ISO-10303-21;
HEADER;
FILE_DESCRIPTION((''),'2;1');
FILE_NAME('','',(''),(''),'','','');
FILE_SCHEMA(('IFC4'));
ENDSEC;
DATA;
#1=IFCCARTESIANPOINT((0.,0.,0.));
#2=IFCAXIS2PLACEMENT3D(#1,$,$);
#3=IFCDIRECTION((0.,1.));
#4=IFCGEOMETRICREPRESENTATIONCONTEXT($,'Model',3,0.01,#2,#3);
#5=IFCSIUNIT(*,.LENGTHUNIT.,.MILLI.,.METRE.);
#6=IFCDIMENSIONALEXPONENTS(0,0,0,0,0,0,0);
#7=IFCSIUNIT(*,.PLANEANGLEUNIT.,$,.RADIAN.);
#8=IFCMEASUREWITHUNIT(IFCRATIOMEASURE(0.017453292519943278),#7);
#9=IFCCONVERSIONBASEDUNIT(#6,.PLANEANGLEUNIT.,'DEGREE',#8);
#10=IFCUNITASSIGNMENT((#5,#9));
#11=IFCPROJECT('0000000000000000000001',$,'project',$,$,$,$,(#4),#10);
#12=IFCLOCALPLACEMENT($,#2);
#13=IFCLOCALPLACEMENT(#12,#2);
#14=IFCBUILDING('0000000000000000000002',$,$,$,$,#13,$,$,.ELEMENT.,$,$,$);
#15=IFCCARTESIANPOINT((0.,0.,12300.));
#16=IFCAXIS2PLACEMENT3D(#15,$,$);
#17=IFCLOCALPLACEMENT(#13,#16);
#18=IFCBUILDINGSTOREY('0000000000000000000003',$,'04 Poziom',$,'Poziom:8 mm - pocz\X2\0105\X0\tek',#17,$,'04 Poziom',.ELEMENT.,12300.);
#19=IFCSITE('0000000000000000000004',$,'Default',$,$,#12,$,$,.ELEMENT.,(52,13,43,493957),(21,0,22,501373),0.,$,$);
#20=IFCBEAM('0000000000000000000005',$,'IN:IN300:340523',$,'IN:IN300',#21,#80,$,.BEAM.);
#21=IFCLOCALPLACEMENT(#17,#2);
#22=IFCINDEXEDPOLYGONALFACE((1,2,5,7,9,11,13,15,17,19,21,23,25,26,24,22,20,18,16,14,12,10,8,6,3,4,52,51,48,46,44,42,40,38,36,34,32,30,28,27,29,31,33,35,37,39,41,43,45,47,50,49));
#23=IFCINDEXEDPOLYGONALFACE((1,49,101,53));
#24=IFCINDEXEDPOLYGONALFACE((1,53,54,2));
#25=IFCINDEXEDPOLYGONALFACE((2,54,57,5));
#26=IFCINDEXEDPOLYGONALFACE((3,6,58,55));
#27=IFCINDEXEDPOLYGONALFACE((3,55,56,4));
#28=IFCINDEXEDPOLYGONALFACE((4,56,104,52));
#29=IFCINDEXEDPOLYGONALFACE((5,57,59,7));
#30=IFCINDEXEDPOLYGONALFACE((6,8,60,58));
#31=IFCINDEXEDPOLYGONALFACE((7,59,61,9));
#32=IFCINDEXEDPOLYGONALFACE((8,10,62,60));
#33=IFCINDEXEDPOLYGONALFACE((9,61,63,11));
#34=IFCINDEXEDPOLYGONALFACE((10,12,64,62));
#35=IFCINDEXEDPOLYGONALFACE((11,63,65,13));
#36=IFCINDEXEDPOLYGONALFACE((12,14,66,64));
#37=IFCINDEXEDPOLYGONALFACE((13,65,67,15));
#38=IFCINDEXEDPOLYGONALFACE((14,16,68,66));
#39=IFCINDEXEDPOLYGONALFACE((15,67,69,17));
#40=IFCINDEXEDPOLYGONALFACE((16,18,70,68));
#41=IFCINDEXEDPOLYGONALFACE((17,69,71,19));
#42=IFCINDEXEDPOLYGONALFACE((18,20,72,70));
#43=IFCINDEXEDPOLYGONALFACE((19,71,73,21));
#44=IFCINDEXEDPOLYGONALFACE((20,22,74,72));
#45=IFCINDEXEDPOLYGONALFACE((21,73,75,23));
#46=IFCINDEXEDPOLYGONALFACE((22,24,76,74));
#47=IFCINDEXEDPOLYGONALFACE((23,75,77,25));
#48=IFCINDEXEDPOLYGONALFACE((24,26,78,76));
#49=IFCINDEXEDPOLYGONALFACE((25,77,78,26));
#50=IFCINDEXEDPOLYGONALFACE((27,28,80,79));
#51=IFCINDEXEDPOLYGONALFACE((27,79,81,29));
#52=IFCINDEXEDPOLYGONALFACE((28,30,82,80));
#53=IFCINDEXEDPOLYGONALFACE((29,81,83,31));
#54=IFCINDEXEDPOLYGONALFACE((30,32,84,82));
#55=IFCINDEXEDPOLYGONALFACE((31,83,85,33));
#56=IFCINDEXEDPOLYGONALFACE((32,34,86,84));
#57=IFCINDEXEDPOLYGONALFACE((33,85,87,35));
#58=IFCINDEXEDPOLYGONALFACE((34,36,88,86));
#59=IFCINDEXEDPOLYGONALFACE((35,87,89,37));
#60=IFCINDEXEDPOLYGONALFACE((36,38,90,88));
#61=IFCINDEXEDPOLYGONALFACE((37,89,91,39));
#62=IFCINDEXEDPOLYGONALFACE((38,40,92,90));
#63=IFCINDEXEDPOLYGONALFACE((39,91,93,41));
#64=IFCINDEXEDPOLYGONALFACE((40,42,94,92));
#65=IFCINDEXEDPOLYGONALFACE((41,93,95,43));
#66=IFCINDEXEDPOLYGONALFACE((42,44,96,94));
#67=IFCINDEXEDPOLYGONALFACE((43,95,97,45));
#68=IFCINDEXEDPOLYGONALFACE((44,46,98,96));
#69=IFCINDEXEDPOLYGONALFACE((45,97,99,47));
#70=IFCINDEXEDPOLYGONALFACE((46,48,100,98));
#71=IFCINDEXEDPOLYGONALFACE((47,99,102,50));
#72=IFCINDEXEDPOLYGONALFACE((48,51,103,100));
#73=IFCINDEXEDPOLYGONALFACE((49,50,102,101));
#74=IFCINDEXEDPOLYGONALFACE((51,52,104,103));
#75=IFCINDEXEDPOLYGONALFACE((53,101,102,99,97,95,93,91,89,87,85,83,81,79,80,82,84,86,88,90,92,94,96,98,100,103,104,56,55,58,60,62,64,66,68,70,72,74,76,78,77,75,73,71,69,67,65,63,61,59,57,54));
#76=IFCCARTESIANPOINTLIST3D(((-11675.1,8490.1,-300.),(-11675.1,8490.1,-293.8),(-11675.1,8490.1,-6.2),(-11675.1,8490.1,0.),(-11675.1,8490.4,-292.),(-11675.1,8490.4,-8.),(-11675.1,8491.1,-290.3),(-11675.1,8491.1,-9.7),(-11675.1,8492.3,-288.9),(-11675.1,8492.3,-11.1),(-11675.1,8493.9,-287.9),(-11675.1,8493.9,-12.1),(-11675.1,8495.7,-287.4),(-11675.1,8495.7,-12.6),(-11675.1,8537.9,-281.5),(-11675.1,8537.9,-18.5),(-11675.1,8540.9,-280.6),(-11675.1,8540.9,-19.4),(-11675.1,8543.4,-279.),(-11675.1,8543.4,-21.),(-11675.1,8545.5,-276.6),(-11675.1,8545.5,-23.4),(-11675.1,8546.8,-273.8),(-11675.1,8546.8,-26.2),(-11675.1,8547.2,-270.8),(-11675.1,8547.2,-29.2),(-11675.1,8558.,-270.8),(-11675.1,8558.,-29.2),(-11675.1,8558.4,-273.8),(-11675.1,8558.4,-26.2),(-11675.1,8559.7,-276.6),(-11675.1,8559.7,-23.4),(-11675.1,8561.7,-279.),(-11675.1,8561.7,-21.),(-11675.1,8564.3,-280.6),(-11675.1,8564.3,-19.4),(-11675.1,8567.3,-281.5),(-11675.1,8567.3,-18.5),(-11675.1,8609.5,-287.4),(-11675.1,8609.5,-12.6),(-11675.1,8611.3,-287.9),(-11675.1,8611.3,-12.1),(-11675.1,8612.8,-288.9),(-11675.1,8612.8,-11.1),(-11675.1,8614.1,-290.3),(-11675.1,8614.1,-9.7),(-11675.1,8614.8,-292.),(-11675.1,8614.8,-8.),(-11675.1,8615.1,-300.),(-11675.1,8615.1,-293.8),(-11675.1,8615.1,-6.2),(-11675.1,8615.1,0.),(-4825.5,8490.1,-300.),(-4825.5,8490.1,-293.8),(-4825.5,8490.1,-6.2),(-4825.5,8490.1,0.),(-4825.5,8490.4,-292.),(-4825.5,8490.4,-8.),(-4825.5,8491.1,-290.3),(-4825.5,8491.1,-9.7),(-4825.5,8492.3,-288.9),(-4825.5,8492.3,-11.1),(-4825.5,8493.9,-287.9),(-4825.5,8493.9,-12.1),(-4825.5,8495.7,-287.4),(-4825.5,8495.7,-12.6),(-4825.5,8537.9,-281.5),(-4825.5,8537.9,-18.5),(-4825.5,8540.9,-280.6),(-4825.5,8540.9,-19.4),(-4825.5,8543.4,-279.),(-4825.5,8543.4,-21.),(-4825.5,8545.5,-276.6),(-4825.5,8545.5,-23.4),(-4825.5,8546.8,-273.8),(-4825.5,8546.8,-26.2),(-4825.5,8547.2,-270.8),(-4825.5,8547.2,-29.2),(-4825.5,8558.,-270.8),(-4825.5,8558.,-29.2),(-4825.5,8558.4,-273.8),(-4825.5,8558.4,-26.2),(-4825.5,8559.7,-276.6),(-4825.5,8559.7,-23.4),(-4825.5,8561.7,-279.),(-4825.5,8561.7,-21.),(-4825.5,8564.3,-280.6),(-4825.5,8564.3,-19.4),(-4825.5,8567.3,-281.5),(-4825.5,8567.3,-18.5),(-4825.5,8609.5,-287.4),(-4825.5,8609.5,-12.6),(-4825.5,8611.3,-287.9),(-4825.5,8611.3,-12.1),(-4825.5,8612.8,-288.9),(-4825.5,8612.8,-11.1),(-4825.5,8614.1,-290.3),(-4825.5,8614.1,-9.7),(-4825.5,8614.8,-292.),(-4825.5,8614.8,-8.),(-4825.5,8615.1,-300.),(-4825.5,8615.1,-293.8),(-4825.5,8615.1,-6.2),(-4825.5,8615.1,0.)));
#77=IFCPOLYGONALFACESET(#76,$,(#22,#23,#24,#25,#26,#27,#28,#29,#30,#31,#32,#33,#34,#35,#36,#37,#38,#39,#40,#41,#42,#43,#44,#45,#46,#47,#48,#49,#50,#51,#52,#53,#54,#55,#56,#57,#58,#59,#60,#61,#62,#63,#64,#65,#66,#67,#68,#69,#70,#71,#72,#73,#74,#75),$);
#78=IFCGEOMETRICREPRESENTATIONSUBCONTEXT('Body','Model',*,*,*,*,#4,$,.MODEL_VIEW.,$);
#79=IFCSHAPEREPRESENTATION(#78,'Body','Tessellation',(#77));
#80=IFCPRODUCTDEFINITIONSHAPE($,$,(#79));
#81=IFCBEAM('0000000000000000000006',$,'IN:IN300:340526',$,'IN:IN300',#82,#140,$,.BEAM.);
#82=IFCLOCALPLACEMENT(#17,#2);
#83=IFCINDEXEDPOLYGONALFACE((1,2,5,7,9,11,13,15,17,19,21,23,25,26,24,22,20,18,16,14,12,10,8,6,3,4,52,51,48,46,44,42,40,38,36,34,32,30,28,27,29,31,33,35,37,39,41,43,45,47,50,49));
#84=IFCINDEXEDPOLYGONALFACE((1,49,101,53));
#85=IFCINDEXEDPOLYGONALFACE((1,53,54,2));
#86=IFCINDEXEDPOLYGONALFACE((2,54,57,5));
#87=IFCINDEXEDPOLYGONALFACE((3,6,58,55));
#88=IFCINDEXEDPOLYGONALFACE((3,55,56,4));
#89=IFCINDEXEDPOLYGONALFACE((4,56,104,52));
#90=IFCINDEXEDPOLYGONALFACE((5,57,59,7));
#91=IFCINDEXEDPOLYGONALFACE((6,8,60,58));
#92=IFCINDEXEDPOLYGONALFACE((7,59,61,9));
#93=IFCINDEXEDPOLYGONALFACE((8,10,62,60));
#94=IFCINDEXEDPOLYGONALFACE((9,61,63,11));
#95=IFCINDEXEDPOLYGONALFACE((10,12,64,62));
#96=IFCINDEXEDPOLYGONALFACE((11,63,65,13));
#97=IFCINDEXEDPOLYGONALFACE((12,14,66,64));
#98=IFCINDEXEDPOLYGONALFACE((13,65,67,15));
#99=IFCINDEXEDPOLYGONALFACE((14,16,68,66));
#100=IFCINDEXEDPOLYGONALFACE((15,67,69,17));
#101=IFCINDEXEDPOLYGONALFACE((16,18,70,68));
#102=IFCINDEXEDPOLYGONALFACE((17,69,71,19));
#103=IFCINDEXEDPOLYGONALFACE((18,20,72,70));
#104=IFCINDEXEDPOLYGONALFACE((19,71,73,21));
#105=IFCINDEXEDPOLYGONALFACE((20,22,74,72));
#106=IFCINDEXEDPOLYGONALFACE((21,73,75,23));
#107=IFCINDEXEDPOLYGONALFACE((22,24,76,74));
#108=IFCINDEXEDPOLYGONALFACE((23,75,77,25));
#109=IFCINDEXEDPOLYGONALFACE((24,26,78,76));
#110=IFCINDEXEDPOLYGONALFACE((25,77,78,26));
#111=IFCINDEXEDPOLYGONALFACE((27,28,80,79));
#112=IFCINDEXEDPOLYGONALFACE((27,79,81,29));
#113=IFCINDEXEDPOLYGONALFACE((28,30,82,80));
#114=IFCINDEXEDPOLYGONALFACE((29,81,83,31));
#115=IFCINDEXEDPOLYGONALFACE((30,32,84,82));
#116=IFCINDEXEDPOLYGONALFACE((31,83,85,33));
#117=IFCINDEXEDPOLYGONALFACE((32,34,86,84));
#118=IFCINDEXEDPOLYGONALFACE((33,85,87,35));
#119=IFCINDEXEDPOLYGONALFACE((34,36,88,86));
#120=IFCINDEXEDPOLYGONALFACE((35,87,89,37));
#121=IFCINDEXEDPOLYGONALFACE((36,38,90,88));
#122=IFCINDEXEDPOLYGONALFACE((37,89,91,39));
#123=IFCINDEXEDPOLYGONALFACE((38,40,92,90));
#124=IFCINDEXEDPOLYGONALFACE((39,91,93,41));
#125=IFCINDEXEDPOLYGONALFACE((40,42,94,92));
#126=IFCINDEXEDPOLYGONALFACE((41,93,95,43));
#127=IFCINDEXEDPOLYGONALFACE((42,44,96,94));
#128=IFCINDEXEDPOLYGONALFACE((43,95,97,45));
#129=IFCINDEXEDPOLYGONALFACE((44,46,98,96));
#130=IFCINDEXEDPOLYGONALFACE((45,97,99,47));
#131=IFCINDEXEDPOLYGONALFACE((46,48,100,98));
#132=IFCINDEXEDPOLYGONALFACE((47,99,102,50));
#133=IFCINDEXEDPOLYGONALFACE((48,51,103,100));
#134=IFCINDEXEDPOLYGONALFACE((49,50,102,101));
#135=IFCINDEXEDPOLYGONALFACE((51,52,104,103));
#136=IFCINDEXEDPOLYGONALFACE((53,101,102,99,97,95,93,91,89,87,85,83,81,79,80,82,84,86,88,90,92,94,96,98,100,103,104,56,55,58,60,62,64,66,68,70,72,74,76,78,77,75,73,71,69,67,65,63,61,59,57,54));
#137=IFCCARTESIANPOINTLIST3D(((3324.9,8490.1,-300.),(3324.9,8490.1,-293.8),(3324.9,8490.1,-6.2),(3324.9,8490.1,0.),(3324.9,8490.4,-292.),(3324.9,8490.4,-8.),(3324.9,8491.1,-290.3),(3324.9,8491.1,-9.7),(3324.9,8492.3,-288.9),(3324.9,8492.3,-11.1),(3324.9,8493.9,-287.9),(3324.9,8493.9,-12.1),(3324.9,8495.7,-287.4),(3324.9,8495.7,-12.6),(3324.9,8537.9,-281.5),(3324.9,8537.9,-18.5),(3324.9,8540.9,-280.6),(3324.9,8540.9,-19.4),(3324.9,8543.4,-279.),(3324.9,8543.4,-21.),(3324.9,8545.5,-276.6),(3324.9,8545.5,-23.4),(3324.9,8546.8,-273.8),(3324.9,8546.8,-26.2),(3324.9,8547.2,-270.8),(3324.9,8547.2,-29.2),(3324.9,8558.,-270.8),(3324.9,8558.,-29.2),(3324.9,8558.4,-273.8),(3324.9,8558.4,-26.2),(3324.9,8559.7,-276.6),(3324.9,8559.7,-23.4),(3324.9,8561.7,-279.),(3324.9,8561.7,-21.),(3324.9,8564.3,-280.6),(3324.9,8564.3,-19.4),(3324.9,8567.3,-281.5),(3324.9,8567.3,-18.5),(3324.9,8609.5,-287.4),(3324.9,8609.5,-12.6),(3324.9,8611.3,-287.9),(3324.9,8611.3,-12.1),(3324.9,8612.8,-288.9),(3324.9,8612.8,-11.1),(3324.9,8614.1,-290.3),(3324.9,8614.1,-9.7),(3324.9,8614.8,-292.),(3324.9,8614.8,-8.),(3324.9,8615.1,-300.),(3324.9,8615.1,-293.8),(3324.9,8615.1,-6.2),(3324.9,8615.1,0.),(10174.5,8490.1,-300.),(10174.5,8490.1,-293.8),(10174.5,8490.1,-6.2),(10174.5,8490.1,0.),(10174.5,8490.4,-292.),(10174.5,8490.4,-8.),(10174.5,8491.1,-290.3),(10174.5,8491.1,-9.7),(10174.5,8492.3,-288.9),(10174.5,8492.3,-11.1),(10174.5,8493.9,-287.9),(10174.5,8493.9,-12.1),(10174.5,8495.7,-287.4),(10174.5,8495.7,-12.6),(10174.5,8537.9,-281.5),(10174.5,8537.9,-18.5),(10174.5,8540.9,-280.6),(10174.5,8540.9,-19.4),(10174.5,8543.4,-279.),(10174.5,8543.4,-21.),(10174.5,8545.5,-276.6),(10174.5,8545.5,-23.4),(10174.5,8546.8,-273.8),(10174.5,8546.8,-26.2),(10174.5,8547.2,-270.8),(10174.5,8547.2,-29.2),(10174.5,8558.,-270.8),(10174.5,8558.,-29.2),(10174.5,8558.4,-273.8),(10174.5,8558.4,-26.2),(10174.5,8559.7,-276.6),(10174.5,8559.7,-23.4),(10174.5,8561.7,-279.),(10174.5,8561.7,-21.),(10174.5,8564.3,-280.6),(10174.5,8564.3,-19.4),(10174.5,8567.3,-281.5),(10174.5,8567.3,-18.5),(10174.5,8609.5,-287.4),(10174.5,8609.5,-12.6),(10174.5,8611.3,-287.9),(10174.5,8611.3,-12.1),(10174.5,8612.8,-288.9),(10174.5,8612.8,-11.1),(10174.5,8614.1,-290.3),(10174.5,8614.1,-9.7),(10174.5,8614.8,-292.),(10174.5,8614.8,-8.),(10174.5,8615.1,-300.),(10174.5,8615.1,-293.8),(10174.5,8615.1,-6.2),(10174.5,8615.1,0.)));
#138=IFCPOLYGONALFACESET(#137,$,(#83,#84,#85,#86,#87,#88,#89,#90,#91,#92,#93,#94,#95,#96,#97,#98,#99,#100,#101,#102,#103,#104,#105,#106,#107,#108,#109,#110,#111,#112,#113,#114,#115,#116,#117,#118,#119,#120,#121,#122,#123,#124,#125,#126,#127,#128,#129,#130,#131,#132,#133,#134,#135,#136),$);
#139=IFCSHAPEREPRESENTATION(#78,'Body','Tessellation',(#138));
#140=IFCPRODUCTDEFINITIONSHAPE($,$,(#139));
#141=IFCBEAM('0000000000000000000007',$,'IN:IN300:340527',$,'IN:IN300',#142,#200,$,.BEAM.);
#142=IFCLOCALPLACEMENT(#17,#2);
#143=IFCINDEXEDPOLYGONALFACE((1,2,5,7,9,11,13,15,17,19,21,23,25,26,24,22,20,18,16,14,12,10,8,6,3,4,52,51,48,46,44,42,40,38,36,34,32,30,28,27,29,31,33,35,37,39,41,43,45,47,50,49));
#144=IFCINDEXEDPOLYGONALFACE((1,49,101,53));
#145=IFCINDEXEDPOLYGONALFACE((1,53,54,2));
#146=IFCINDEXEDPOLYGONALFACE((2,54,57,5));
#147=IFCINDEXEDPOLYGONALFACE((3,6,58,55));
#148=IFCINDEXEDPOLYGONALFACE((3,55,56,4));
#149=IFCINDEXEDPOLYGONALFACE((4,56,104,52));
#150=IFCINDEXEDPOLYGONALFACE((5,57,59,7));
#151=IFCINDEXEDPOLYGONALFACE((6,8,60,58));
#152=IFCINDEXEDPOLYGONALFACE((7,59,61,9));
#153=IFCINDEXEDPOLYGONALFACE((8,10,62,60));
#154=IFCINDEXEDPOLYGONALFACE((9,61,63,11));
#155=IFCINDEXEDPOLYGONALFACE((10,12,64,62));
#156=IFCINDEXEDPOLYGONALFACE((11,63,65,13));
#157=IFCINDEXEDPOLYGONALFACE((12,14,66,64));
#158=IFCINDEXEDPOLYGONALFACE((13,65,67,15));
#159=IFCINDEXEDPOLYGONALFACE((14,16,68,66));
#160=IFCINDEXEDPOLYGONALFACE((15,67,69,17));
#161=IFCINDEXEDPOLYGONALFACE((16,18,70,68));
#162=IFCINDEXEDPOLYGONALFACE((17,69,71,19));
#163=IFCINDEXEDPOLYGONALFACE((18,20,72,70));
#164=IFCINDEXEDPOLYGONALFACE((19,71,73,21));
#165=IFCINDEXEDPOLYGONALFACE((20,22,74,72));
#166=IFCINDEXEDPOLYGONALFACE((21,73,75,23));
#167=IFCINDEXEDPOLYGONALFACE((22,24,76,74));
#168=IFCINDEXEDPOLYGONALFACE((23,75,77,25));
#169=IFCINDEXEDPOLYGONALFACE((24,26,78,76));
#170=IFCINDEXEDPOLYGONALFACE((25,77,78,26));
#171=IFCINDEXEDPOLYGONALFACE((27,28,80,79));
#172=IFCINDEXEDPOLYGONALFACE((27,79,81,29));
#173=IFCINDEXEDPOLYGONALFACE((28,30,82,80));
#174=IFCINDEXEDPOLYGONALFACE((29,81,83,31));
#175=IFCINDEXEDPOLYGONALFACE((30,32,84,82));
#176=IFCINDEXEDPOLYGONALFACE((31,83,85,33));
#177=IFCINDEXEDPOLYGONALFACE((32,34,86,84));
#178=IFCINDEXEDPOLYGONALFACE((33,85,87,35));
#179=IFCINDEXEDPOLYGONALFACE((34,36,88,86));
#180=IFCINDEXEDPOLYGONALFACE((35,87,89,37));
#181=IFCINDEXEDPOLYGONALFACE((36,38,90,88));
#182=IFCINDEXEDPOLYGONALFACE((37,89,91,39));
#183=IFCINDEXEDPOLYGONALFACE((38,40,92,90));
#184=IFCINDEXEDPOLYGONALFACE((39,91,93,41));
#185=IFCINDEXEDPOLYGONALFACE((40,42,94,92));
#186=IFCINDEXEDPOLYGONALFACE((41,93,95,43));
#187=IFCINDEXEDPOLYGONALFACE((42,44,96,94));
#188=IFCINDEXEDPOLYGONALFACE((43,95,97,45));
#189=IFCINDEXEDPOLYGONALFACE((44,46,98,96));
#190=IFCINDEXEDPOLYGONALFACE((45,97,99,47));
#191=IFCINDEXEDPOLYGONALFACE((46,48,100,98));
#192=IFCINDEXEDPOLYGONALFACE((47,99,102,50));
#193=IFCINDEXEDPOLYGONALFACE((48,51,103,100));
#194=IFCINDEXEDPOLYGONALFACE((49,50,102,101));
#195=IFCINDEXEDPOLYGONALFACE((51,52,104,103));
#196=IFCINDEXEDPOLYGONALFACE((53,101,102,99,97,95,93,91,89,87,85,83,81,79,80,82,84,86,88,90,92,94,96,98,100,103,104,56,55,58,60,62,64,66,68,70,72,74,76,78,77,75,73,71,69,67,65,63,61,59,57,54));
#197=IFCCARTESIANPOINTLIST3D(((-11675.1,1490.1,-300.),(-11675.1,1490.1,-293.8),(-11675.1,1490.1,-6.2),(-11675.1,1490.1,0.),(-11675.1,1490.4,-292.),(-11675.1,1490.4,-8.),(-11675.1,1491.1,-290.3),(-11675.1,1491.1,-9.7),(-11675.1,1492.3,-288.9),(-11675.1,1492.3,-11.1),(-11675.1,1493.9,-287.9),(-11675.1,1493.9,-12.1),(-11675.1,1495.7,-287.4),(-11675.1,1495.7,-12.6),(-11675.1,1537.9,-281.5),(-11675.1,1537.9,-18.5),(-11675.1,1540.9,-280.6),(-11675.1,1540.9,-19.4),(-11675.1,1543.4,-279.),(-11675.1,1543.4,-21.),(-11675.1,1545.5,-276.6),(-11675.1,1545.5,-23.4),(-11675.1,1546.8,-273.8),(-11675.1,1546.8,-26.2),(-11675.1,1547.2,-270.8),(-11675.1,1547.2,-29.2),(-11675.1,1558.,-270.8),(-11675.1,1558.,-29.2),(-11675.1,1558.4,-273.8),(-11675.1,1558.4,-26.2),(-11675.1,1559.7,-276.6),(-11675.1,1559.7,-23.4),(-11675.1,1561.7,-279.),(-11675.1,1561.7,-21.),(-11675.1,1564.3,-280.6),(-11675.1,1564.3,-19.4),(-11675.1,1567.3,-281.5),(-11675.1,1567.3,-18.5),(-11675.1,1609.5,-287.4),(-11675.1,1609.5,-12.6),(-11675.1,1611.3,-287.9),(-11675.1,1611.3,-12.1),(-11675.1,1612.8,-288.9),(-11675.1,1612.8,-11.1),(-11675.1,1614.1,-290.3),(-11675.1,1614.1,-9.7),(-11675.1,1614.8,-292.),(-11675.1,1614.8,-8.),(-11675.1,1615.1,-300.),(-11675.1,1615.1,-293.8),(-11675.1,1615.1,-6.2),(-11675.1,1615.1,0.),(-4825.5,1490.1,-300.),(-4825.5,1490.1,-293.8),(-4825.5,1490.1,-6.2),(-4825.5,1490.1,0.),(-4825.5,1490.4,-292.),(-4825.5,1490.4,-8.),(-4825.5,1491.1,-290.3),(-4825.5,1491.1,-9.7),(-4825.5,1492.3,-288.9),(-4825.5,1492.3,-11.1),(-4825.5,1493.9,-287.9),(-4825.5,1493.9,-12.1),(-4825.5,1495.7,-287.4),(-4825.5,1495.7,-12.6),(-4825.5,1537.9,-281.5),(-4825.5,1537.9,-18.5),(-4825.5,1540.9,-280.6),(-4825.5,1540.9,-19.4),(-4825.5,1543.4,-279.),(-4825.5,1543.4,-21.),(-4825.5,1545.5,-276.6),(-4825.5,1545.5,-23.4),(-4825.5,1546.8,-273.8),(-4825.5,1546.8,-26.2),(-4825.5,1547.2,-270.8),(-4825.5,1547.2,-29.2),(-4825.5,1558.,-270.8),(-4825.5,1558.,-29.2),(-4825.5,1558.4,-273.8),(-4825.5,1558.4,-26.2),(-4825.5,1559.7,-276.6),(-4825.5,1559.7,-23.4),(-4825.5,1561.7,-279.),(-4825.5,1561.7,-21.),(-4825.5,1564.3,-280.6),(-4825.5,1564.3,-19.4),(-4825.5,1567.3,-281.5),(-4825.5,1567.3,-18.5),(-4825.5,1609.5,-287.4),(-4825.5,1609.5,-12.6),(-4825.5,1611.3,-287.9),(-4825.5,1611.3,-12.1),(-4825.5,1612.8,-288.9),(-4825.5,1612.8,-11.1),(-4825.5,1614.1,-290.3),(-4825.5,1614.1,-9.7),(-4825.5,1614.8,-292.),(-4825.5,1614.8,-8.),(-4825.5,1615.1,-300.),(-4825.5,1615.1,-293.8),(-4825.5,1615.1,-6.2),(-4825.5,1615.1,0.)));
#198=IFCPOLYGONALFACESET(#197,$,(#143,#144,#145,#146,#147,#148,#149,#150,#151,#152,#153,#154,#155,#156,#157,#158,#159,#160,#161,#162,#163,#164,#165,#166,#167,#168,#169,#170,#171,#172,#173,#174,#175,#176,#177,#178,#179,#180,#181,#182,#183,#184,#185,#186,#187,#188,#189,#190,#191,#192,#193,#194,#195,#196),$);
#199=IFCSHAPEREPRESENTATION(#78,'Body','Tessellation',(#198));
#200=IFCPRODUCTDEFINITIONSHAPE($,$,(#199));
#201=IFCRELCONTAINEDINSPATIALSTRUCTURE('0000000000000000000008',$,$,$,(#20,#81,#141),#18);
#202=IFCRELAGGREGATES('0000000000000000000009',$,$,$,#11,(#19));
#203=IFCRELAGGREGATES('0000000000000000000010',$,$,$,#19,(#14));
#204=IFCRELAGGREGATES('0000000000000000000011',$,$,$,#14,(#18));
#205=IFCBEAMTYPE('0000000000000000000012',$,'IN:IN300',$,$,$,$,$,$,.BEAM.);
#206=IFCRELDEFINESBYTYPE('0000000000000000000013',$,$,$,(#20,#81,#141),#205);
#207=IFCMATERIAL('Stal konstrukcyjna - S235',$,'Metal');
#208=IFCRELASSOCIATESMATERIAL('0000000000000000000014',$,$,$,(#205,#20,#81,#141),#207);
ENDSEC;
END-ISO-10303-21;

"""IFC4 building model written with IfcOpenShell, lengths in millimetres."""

from ifc_helpers import new_model, entity, si_unit, converted_unit, direction, frame, origin, place, context, subcontext, project, spatial, line, arc, indexed_curve, outline, extrude, source, transform, mapped, material, type_object, type_shapes, element, save


model = new_model("IFC4")

# Units and contexts
model_context = context("Model", 3, precision=0.01, world=origin(), true_north=direction((0.0, 1.0)))
body_context = subcontext(model_context, "Body", "Model", "MODEL_VIEW")
ifc_project = project(units=[si_unit("LENGTHUNIT", "METRE", prefix="MILLI"), converted_unit("PLANEANGLEUNIT", "DEGREE", entity("IfcRatioMeasure", 0.017453292519943278), si_unit("PLANEANGLEUNIT", "RADIAN"), dimensions=[0, 0, 0, 0, 0, 0, 0])], contexts=[model_context])

# Site, building, storey
site_placement = place(None, origin())
site = spatial("IfcSite", under=ifc_project, at=site_placement, Name="Default", CompositionType="ELEMENT", RefLatitude=(52, 13, 43, 493957), RefLongitude=(21, 0, 22, 501373), RefElevation=0.0)
building_placement = place(site_placement, origin())
building = spatial("IfcBuilding", under=site, at=building_placement, CompositionType="ELEMENT")
storey_placement = place(building_placement, frame((0.0, 0.0, 12300.0)))
storey = spatial("IfcBuildingStorey", under=building, at=storey_placement, Name="04 Poziom", ObjectType="Poziom:8 mm - początek", LongName="04 Poziom", CompositionType="ELEMENT", Elevation=12300.0)

# Shared definitions
ifc_material_1 = material(Name="Stal konstrukcyjna - S235", Category="Metal")

# Beams
beam_type_1 = type_object("IfcBeamType", Name="IN:IN300", PredefinedType="BEAM", material=ifc_material_1)
shared_shape_1 = source(origin(), body_context, "Body", "SweptSolid", [
    extrude(outline(indexed_curve([(143.8, -62.5), (150.0, -62.5), (150.0, 62.5), (143.8, 62.5), (139.6, 60.9), (137.4, 56.9), (131.5, 14.7), (127.9, 8.1), (120.8, 5.4), (-120.8, 5.4), (-127.9, 8.1), (-131.5, 14.7), (-137.4, 56.9), (-139.6, 60.9), (-143.8, 62.5), (-150.0, 62.5), (-150.0, -62.5), (-143.8, -62.5), (-139.6, -60.9), (-137.4, -56.9), (-131.5, -14.7), (-127.9, -8.1), (-120.8, -5.4), (120.8, -5.4), (127.9, -8.1), (131.5, -14.7), (137.4, -56.9), (139.6, -60.9)], segments=[line(1, 2, 3, 4), arc(4, 5, 6), line(6, 7), arc(7, 8, 9), line(9, 10), arc(10, 11, 12), line(12, 13), arc(13, 14, 15), line(15, 16, 17, 18), arc(18, 19, 20), line(20, 21), arc(21, 22, 23), line(23, 24), arc(24, 25, 26), line(26, 27), arc(27, 28, 1)], self_intersect=False)), frame((-3424.8, 0.0, 0.0), z_axis=(1.0, 0.0, 0.0), x_axis=(0.0, 0.0, -1.0)), (0.0, 0.0, 1.0), 6849.6),
])
type_shapes(beam_type_1, [shared_shape_1])
for number, where, name in (
    (1, (-8250.3, 8552.6, -150.0), "IN:IN300:340523"),
    (2, (6749.7, 8552.6, -150.0), "IN:IN300:340526"),
    (3, (-8250.3, 1552.6, -150.0), "IN:IN300:340527"),
):
    element("IfcBeam", number, at=place(storey_placement, frame(where)), inside=storey, type_object=beam_type_1, material=ifc_material_1, Name=name, ObjectType="IN:IN300", PredefinedType="BEAM", context=body_context, shape_type="MappedRepresentation", body=[
        mapped(shared_shape_1, transform((0.0, 0.0, 0.0), scale=1.0)),
    ])

save(model, "model.ifc")
